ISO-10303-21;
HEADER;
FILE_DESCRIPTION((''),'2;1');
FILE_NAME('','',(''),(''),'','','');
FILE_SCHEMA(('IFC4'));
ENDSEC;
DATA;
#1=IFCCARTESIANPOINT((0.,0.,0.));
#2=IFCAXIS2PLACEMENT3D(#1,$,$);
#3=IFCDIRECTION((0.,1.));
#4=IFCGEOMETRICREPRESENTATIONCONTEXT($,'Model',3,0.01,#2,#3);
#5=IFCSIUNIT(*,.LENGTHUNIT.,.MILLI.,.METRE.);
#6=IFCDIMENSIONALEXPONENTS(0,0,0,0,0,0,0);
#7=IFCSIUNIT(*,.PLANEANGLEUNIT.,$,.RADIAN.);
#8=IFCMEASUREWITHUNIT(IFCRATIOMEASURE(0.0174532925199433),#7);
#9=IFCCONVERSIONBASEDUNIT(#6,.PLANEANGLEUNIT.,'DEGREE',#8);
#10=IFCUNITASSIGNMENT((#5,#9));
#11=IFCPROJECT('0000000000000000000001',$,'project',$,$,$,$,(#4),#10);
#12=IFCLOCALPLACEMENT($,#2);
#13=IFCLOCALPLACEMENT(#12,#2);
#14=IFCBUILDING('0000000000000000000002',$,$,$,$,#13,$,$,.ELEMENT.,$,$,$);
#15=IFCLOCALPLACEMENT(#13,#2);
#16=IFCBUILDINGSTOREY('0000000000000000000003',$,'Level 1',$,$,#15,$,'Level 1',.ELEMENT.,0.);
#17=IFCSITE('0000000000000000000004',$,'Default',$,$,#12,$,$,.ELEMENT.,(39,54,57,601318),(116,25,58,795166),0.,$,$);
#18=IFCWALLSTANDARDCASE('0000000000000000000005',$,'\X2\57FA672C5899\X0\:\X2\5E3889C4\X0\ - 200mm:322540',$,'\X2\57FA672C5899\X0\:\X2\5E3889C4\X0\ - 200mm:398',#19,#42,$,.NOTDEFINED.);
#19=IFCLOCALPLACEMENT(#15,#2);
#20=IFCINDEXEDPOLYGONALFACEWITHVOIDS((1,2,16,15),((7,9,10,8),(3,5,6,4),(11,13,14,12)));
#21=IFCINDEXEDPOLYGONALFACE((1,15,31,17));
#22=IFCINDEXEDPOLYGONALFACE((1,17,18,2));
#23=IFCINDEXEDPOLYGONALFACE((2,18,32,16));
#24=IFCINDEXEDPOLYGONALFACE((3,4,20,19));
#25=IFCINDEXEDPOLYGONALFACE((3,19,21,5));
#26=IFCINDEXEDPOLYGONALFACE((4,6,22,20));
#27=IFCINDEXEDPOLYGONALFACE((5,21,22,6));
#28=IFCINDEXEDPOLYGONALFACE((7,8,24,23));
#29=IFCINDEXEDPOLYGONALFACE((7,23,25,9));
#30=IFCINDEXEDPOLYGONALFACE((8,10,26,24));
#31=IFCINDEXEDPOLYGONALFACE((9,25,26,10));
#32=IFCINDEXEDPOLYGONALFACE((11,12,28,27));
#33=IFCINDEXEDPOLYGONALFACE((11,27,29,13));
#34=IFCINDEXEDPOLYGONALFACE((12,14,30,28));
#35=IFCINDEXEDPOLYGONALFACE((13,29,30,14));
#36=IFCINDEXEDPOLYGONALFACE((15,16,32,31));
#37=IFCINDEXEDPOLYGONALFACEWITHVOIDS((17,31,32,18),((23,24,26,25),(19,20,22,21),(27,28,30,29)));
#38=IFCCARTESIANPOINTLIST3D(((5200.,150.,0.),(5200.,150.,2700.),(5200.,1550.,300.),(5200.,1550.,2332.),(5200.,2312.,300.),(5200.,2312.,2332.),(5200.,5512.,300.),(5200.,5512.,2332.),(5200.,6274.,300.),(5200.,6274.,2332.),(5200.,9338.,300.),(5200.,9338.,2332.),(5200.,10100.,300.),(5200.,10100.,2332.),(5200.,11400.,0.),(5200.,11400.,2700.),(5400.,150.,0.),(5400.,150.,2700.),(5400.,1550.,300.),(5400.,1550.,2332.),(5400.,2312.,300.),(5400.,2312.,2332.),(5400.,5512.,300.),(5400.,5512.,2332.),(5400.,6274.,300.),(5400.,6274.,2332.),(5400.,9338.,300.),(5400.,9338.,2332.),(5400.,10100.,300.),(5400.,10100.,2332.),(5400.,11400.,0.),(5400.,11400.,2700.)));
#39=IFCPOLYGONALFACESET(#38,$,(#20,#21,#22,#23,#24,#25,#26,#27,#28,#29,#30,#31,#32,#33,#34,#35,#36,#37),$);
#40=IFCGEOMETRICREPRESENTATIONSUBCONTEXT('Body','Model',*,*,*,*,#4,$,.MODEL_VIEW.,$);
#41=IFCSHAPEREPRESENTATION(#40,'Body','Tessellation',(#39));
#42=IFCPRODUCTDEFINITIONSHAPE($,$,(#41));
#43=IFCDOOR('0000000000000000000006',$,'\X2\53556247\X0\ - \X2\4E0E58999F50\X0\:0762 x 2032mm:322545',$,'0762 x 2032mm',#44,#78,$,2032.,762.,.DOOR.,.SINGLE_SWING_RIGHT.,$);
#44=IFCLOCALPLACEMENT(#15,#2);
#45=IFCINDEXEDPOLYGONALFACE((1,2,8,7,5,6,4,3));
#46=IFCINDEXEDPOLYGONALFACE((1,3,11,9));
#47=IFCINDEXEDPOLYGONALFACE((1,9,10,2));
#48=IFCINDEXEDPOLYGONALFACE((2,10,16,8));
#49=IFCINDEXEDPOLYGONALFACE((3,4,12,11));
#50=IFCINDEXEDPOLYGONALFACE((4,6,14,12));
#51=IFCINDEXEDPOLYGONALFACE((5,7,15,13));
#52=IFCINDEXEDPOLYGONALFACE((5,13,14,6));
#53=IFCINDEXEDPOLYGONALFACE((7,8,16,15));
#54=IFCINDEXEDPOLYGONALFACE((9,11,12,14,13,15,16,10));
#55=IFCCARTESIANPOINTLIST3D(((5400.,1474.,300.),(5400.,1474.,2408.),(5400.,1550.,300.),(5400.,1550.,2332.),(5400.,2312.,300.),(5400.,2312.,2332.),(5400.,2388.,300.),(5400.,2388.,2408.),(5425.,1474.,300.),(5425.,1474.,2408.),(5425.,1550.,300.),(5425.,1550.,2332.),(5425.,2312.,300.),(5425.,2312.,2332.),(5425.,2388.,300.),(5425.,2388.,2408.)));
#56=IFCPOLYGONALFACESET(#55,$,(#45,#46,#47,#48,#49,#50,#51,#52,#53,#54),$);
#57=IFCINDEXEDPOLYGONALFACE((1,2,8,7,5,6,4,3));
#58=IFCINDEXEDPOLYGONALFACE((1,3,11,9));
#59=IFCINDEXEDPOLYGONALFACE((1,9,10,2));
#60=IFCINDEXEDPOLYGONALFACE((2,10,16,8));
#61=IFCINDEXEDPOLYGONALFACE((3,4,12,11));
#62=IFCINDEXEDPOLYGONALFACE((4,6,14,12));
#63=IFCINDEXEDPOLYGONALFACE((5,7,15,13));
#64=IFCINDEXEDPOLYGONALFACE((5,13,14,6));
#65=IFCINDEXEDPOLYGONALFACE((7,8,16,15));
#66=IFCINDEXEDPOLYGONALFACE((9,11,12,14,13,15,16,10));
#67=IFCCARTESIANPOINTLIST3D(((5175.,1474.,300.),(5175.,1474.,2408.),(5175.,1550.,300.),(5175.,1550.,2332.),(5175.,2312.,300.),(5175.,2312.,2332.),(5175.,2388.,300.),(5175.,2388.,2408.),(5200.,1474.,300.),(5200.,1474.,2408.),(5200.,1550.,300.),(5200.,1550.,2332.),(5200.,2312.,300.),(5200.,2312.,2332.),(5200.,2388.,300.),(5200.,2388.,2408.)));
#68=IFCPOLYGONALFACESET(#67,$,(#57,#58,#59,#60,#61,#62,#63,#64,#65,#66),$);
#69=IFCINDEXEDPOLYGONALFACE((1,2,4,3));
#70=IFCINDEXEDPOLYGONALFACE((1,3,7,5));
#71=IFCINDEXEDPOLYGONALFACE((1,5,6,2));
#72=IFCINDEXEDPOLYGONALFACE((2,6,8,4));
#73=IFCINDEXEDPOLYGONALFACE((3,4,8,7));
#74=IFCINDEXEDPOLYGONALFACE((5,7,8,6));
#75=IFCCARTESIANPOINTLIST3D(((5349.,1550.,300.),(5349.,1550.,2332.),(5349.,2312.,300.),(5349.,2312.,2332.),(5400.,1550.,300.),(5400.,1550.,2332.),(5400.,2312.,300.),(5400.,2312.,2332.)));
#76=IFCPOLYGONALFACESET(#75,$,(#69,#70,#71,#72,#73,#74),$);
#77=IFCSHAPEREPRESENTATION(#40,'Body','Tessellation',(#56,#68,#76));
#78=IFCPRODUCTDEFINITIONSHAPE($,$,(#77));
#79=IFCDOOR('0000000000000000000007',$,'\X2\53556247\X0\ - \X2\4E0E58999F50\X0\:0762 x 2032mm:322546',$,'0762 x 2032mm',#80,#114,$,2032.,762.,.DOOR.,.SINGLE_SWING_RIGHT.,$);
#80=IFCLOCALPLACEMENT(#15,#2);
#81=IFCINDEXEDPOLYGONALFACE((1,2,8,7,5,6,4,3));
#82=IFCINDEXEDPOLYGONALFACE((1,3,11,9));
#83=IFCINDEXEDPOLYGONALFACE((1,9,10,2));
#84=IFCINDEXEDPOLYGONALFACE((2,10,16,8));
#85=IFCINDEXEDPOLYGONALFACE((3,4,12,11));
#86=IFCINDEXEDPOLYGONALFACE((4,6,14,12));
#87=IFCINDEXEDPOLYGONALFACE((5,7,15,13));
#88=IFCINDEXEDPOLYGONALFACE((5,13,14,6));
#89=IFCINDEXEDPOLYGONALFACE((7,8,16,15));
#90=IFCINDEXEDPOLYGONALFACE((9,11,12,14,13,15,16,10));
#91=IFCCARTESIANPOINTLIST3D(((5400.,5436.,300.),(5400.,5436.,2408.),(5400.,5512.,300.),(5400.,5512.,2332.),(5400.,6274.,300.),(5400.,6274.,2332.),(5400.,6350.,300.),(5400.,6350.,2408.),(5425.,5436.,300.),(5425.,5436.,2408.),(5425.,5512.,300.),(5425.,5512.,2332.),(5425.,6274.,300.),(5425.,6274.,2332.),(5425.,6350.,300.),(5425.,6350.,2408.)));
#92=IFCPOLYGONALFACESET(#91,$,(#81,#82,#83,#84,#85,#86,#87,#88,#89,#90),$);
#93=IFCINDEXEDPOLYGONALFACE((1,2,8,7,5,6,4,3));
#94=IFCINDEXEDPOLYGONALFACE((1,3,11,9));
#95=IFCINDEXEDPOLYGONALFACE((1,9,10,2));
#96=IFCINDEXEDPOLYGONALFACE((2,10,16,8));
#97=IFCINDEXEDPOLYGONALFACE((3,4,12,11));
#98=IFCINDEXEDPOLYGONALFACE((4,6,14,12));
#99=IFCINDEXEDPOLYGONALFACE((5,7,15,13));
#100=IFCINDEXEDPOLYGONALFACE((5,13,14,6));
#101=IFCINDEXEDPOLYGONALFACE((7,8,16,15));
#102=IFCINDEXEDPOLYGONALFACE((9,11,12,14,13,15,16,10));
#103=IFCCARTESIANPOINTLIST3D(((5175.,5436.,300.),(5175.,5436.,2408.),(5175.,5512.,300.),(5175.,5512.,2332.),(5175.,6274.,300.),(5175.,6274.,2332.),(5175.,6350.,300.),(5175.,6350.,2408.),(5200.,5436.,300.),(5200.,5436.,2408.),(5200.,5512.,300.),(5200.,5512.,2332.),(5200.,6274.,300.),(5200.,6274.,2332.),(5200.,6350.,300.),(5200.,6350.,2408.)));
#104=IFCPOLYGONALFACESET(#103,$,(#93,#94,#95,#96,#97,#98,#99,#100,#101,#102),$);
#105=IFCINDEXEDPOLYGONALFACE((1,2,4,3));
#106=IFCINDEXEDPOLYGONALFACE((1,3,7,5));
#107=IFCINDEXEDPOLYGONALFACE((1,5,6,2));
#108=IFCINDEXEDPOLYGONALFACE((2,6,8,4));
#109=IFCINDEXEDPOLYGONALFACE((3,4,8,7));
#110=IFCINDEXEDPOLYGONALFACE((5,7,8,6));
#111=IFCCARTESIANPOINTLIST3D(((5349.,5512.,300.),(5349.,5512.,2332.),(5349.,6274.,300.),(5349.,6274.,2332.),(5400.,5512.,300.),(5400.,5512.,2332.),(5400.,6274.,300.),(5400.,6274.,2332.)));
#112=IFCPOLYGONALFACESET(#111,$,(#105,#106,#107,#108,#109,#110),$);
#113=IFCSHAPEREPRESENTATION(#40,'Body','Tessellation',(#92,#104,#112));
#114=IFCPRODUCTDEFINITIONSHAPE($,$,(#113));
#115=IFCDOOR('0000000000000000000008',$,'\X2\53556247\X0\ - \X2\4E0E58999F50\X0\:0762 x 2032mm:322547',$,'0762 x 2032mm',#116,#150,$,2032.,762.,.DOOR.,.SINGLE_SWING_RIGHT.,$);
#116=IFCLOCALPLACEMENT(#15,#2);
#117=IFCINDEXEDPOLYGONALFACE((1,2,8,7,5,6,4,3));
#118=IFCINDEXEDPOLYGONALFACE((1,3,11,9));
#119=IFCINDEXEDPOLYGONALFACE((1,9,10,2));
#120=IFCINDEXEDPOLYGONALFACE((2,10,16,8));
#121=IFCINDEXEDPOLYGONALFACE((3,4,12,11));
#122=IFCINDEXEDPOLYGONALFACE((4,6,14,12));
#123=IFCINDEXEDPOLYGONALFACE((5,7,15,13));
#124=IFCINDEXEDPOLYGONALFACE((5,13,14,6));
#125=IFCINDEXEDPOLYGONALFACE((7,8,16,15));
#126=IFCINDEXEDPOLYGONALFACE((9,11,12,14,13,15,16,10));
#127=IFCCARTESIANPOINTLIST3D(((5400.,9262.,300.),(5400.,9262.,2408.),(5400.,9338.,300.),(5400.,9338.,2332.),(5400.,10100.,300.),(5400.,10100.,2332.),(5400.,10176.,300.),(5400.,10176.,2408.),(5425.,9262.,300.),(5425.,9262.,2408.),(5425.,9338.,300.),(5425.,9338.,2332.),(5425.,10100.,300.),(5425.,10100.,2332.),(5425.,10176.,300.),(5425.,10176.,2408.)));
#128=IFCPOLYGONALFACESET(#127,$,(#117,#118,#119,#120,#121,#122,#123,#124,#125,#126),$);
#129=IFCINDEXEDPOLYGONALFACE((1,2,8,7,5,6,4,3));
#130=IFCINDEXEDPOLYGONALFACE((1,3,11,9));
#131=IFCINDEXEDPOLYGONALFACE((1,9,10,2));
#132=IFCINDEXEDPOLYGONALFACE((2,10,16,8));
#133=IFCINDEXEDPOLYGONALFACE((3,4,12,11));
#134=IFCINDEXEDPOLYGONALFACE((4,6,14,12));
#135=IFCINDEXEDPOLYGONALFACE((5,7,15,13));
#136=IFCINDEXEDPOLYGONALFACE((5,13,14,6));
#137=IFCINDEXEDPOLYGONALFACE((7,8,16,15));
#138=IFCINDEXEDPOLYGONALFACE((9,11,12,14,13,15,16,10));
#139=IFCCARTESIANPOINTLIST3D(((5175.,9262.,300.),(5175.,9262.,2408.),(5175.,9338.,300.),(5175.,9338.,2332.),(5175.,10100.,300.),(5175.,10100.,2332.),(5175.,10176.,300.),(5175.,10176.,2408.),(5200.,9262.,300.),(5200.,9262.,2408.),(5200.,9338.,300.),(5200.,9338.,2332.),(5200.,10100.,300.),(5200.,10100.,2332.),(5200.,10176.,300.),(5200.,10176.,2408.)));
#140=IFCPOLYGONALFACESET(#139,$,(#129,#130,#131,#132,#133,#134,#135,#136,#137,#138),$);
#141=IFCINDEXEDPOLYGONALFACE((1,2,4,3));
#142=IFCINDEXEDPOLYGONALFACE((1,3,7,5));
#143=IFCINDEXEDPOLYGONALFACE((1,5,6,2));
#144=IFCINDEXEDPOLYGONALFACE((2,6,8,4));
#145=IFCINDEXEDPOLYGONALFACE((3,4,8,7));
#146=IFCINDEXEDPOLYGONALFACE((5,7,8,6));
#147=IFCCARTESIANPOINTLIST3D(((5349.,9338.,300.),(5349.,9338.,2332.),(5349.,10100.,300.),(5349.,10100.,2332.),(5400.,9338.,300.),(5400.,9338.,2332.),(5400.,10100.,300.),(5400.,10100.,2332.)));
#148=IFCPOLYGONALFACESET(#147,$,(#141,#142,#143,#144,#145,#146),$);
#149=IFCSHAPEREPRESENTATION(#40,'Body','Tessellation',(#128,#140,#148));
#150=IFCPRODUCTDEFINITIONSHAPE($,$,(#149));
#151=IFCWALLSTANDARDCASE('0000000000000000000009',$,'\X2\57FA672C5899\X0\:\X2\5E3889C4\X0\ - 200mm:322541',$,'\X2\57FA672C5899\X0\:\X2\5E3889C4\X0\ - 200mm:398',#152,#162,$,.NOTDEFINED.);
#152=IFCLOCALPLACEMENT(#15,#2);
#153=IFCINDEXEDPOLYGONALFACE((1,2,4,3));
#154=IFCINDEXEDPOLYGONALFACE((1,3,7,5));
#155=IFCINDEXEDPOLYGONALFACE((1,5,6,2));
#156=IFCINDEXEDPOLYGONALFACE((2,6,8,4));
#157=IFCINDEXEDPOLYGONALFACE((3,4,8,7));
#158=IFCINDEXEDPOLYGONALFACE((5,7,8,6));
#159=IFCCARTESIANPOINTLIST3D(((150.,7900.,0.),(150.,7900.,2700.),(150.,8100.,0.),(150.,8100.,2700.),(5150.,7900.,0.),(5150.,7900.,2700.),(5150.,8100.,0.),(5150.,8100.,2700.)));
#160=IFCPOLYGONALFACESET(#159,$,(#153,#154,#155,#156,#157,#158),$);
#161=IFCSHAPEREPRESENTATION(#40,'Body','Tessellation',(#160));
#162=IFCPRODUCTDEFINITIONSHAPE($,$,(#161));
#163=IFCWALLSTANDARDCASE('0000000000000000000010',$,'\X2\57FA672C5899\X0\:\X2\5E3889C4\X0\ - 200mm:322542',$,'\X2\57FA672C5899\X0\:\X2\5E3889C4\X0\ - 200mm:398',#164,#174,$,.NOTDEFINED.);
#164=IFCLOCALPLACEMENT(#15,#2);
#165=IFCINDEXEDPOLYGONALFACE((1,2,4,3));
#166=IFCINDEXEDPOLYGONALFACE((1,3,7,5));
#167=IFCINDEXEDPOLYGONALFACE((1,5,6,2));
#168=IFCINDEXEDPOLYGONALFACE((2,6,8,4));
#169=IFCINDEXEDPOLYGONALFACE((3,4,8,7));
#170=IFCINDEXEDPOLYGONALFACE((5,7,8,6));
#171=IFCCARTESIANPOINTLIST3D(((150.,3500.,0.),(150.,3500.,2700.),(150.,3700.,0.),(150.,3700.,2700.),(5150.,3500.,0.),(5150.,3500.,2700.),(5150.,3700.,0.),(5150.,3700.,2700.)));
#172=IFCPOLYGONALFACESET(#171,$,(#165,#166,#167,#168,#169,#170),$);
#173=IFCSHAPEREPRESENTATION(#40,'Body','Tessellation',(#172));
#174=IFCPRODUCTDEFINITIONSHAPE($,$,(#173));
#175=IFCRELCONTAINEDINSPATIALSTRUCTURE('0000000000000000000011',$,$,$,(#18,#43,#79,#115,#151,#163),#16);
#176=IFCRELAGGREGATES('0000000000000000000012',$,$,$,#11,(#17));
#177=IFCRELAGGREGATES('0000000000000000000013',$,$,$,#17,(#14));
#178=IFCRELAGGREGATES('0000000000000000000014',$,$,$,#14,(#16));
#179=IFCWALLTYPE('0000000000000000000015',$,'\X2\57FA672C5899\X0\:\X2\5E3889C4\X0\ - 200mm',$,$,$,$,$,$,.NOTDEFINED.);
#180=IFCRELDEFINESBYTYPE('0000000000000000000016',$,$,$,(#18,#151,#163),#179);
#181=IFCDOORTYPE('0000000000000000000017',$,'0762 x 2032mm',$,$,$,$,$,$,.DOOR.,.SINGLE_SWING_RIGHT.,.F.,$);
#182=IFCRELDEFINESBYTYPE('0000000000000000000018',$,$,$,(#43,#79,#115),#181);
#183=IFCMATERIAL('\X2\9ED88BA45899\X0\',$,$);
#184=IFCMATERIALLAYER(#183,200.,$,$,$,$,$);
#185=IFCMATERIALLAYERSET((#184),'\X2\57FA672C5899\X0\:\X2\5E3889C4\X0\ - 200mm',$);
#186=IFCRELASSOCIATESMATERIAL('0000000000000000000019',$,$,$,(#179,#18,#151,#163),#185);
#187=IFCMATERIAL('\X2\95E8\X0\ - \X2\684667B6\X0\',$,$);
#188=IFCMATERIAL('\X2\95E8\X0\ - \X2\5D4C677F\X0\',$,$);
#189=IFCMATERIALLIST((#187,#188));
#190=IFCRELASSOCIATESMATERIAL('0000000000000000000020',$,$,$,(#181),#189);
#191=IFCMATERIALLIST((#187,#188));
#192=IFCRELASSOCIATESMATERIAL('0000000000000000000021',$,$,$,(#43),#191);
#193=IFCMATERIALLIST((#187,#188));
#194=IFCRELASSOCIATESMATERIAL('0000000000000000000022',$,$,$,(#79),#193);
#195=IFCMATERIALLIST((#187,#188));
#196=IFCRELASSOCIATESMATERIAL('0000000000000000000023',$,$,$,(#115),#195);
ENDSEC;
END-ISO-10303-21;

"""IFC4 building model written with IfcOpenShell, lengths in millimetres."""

from ifc_helpers import new_model, entity, si_unit, converted_unit, direction, frame, frame_2d, origin, place, context, subcontext, project, spatial, polyline, rectangle, outline, extrude, clip, bounded_halfspace, source, transform, mapped, material, material_list, layer, layer_set, layer_usage, type_object, type_shapes, element, fill, save


model = new_model("IFC4")

# Units and contexts
model_context = context("Model", 3, precision=0.01, world=origin(), true_north=direction((0.0, 1.0)))
body_context = subcontext(model_context, "Body", "Model", "MODEL_VIEW")
ifc_project = project(units=[si_unit("LENGTHUNIT", "METRE", prefix="MILLI"), converted_unit("PLANEANGLEUNIT", "DEGREE", entity("IfcRatioMeasure", 0.0174532925199433), si_unit("PLANEANGLEUNIT", "RADIAN"), dimensions=[0, 0, 0, 0, 0, 0, 0])], contexts=[model_context])

# Site, building, storey
site_placement = place(None, origin())
site = spatial("IfcSite", under=ifc_project, at=site_placement, Name="Default", CompositionType="ELEMENT", RefLatitude=(39, 54, 57, 601318), RefLongitude=(116, 25, 58, 795166), RefElevation=0.0)
building_placement = place(site_placement, origin())
building = spatial("IfcBuilding", under=site, at=building_placement, CompositionType="ELEMENT")
storey_placement = place(building_placement, origin())
storey = spatial("IfcBuildingStorey", under=building, at=storey_placement, Name="Level 1", LongName="Level 1", CompositionType="ELEMENT", Elevation=0.0)

# Shared definitions
ifc_material_1 = material(Name="默认墙")
ifc_layer_1 = layer(ifc_material_1, 200.0)
ifc_layer_set_1 = layer_set([ifc_layer_1], Name="基本墙:常规 - 200mm")
wall_type = type_object("IfcWallType", Name="基本墙:常规 - 200mm", PredefinedType="NOTDEFINED", material=ifc_layer_set_1)

# Wall, openings, doors
ifc_layer_usage_1 = layer_usage(ifc_layer_set_1, "AXIS2", "NEGATIVE", 100.0)
wall_1_placement = place(storey_placement, frame((5300.0, 11400.0, 0.0), z_axis=(0.0, 0.0, 1.0), x_axis=(0.0, -1.0, 0.0)))
wall_1 = element("IfcWallStandardCase", 1, at=wall_1_placement, inside=storey, type_object=wall_type, material=ifc_layer_usage_1, Name="基本墙:常规 - 200mm:322540", ObjectType="基本墙:常规 - 200mm:398", PredefinedType="NOTDEFINED", context=body_context, shape_type="Clipping", body=[
    clip(extrude(rectangle(XDim=11250.0, YDim=200.0, at=frame_2d((5625.0, 0.0), x_axis=(-1.0, 0.0))), origin(), (0.0, 0.0, 1.0), 2700.0), bounded_halfspace(frame((0.0, -100.0, 2700.0), z_axis=(0.0, 0.0, -1.0), x_axis=(-1.0, 0.0, 0.0)), True, frame((0.0, -100.0, 2700.0)), polyline([(0.0, 0.0), (11250.0, 0.0), (11250.0, 200.0), (0.0, 200.0), (0.0, 0.0)]))),
])
opening_1_placement = place(wall_1_placement, frame((9088.0, -100.0, 300.0)))
opening_1 = element("IfcOpeningElement", 2, at=opening_1_placement, cuts=wall_1, ObjectType="Opening", PredefinedType="OPENING", context=body_context, shape_type="SweptSolid", body=[
    extrude(rectangle(XDim=762.0, YDim=2032.0, at=frame_2d((1016.0, 381.0), x_axis=(0.0, 1.0))), frame((0.0, 0.0, 0.0), z_axis=(0.0, 1.0, 0.0), x_axis=(0.0, 0.0, 1.0)), (0.0, 0.0, 1.0), 200.0),
])
opening_2_placement = place(wall_1_placement, frame((5126.0, -100.0, 300.0)))
opening_2 = element("IfcOpeningElement", 3, at=opening_2_placement, cuts=wall_1, ObjectType="Opening", PredefinedType="OPENING", context=body_context, shape_type="SweptSolid", body=[
    extrude(rectangle(XDim=762.0, YDim=2032.0, at=frame_2d((1016.0, 381.0), x_axis=(0.0, 1.0))), frame((0.0, 0.0, 0.0), z_axis=(0.0, 1.0, 0.0), x_axis=(0.0, 0.0, 1.0)), (0.0, 0.0, 1.0), 200.0),
])
opening_3_placement = place(wall_1_placement, frame((1300.0, -100.0, 300.0)))
opening_3 = element("IfcOpeningElement", 4, at=opening_3_placement, cuts=wall_1, ObjectType="Opening", PredefinedType="OPENING", context=body_context, shape_type="SweptSolid", body=[
    extrude(rectangle(XDim=762.0, YDim=2032.0, at=frame_2d((1016.0, 381.0), x_axis=(0.0, 1.0))), frame((0.0, 0.0, 0.0), z_axis=(0.0, 1.0, 0.0), x_axis=(0.0, 0.0, 1.0)), (0.0, 0.0, 1.0), 200.0),
])
ifc_material_2 = material(Name="门 - 框架")
ifc_material_3 = material(Name="门 - 嵌板")
ifc_material_list_1 = material_list([ifc_material_2, ifc_material_3])
ifc_material_list_2 = material_list([ifc_material_2, ifc_material_3])
door_type_1 = type_object("IfcDoorType", Name="0762 x 2032mm", OperationType="SINGLE_SWING_RIGHT", ParameterTakesPrecedence=False, PredefinedType="DOOR", material=ifc_material_list_2)
shared_shape_1 = source(origin(), body_context, "Body", "SweptSolid", [
    extrude(outline(polyline([(-457.0, -1073.0), (457.0, -1073.0), (457.0, 1035.0), (381.0, 1035.0), (381.0, -997.0), (-381.0, -997.0), (-381.0, 1035.0), (-457.0, 1035.0), (-457.0, -1073.0)])), frame((381.0, 200.0, 1035.0), z_axis=(0.0, 1.0, 0.0), x_axis=(1.0, 0.0, 0.0)), (0.0, 0.0, 1.0), 25.0),
    extrude(outline(polyline([(-1073.0, -457.0), (1035.0, -457.0), (1035.0, -381.0), (-997.0, -381.0), (-997.0, 381.0), (1035.0, 381.0), (1035.0, 457.0), (-1073.0, 457.0), (-1073.0, -457.0)])), frame((381.0, -25.0, 1035.0), z_axis=(0.0, 1.0, 0.0), x_axis=(0.0, 0.0, -1.0)), (0.0, 0.0, 1.0), 25.0),
    extrude(rectangle(XDim=51.0, YDim=762.0, at=frame_2d((0.0, 0.0), x_axis=(1.0, 0.0))), frame((381.0, 174.5, 0.0), z_axis=(0.0, 0.0, 1.0), x_axis=(0.0, 1.0, 0.0)), (0.0, 0.0, 1.0), 2032.0),
])
type_shapes(door_type_1, [shared_shape_1])
door_1_placement = place(opening_1_placement, origin())
door_1 = element("IfcDoor", 5, at=door_1_placement, inside=storey, type_object=door_type_1, material=ifc_material_list_1, Name="单扇 - 与墙齐:0762 x 2032mm:322545", ObjectType="0762 x 2032mm", OperationType="SINGLE_SWING_RIGHT", OverallHeight=2032.0, OverallWidth=762.0, PredefinedType="DOOR", context=body_context, shape_type="MappedRepresentation", body=[
    mapped(shared_shape_1, transform((0.0, 0.0, 0.0), scale=1.0)),
])
fill(opening_1, door_1)
ifc_material_list_3 = material_list([ifc_material_2, ifc_material_3])
door_2_placement = place(opening_2_placement, origin())
door_2 = element("IfcDoor", 6, at=door_2_placement, inside=storey, type_object=door_type_1, material=ifc_material_list_3, Name="单扇 - 与墙齐:0762 x 2032mm:322546", ObjectType="0762 x 2032mm", OperationType="SINGLE_SWING_RIGHT", OverallHeight=2032.0, OverallWidth=762.0, PredefinedType="DOOR", context=body_context, shape_type="MappedRepresentation", body=[
    mapped(shared_shape_1, transform((0.0, 0.0, 0.0), scale=1.0)),
])
fill(opening_2, door_2)
ifc_material_list_4 = material_list([ifc_material_2, ifc_material_3])
door_3_placement = place(opening_3_placement, origin())
door_3 = element("IfcDoor", 7, at=door_3_placement, inside=storey, type_object=door_type_1, material=ifc_material_list_4, Name="单扇 - 与墙齐:0762 x 2032mm:322547", ObjectType="0762 x 2032mm", OperationType="SINGLE_SWING_RIGHT", OverallHeight=2032.0, OverallWidth=762.0, PredefinedType="DOOR", context=body_context, shape_type="MappedRepresentation", body=[
    mapped(shared_shape_1, transform((0.0, 0.0, 0.0), scale=1.0)),
])
fill(opening_3, door_3)

# Walls
ifc_layer_usage_2 = layer_usage(ifc_layer_set_1, "AXIS2", "NEGATIVE", 100.0)
wall_2_placement = place(storey_placement, frame((150.0, 8000.0, 0.0)))
element("IfcWallStandardCase", 8, at=wall_2_placement, inside=storey, type_object=wall_type, material=ifc_layer_usage_2, Name="基本墙:常规 - 200mm:322541", ObjectType="基本墙:常规 - 200mm:398", PredefinedType="NOTDEFINED", context=body_context, shape_type="Clipping", body=[
    clip(extrude(rectangle(XDim=5000.0, YDim=200.0, at=frame_2d((2500.0, 0.0), x_axis=(-1.0, 0.0))), origin(), (0.0, 0.0, 1.0), 2700.0), bounded_halfspace(frame((0.0, -100.0, 2700.0), z_axis=(0.0, 0.0, -1.0), x_axis=(0.0, 1.0, 0.0)), True, frame((0.0, -100.0, 2700.0)), polyline([(0.0, 0.0), (5000.0, 0.0), (5000.0, 200.0), (0.0, 200.0), (0.0, 0.0)]))),
])
ifc_layer_usage_3 = layer_usage(ifc_layer_set_1, "AXIS2", "NEGATIVE", 100.0)
wall_3_placement = place(storey_placement, frame((150.0, 3600.0, 0.0)))
element("IfcWallStandardCase", 9, at=wall_3_placement, inside=storey, type_object=wall_type, material=ifc_layer_usage_3, Name="基本墙:常规 - 200mm:322542", ObjectType="基本墙:常规 - 200mm:398", PredefinedType="NOTDEFINED", context=body_context, shape_type="Clipping", body=[
    clip(extrude(rectangle(XDim=5000.0, YDim=200.0, at=frame_2d((2500.0, 0.0), x_axis=(-1.0, 0.0))), origin(), (0.0, 0.0, 1.0), 2700.0), bounded_halfspace(frame((0.0, -100.0, 2700.0), z_axis=(0.0, 0.0, -1.0), x_axis=(0.0, 1.0, 0.0)), True, frame((0.0, -100.0, 2700.0)), polyline([(0.0, 0.0), (5000.0, 0.0), (5000.0, 200.0), (0.0, 200.0), (0.0, 0.0)]))),
])

save(model, "model.ifc")
